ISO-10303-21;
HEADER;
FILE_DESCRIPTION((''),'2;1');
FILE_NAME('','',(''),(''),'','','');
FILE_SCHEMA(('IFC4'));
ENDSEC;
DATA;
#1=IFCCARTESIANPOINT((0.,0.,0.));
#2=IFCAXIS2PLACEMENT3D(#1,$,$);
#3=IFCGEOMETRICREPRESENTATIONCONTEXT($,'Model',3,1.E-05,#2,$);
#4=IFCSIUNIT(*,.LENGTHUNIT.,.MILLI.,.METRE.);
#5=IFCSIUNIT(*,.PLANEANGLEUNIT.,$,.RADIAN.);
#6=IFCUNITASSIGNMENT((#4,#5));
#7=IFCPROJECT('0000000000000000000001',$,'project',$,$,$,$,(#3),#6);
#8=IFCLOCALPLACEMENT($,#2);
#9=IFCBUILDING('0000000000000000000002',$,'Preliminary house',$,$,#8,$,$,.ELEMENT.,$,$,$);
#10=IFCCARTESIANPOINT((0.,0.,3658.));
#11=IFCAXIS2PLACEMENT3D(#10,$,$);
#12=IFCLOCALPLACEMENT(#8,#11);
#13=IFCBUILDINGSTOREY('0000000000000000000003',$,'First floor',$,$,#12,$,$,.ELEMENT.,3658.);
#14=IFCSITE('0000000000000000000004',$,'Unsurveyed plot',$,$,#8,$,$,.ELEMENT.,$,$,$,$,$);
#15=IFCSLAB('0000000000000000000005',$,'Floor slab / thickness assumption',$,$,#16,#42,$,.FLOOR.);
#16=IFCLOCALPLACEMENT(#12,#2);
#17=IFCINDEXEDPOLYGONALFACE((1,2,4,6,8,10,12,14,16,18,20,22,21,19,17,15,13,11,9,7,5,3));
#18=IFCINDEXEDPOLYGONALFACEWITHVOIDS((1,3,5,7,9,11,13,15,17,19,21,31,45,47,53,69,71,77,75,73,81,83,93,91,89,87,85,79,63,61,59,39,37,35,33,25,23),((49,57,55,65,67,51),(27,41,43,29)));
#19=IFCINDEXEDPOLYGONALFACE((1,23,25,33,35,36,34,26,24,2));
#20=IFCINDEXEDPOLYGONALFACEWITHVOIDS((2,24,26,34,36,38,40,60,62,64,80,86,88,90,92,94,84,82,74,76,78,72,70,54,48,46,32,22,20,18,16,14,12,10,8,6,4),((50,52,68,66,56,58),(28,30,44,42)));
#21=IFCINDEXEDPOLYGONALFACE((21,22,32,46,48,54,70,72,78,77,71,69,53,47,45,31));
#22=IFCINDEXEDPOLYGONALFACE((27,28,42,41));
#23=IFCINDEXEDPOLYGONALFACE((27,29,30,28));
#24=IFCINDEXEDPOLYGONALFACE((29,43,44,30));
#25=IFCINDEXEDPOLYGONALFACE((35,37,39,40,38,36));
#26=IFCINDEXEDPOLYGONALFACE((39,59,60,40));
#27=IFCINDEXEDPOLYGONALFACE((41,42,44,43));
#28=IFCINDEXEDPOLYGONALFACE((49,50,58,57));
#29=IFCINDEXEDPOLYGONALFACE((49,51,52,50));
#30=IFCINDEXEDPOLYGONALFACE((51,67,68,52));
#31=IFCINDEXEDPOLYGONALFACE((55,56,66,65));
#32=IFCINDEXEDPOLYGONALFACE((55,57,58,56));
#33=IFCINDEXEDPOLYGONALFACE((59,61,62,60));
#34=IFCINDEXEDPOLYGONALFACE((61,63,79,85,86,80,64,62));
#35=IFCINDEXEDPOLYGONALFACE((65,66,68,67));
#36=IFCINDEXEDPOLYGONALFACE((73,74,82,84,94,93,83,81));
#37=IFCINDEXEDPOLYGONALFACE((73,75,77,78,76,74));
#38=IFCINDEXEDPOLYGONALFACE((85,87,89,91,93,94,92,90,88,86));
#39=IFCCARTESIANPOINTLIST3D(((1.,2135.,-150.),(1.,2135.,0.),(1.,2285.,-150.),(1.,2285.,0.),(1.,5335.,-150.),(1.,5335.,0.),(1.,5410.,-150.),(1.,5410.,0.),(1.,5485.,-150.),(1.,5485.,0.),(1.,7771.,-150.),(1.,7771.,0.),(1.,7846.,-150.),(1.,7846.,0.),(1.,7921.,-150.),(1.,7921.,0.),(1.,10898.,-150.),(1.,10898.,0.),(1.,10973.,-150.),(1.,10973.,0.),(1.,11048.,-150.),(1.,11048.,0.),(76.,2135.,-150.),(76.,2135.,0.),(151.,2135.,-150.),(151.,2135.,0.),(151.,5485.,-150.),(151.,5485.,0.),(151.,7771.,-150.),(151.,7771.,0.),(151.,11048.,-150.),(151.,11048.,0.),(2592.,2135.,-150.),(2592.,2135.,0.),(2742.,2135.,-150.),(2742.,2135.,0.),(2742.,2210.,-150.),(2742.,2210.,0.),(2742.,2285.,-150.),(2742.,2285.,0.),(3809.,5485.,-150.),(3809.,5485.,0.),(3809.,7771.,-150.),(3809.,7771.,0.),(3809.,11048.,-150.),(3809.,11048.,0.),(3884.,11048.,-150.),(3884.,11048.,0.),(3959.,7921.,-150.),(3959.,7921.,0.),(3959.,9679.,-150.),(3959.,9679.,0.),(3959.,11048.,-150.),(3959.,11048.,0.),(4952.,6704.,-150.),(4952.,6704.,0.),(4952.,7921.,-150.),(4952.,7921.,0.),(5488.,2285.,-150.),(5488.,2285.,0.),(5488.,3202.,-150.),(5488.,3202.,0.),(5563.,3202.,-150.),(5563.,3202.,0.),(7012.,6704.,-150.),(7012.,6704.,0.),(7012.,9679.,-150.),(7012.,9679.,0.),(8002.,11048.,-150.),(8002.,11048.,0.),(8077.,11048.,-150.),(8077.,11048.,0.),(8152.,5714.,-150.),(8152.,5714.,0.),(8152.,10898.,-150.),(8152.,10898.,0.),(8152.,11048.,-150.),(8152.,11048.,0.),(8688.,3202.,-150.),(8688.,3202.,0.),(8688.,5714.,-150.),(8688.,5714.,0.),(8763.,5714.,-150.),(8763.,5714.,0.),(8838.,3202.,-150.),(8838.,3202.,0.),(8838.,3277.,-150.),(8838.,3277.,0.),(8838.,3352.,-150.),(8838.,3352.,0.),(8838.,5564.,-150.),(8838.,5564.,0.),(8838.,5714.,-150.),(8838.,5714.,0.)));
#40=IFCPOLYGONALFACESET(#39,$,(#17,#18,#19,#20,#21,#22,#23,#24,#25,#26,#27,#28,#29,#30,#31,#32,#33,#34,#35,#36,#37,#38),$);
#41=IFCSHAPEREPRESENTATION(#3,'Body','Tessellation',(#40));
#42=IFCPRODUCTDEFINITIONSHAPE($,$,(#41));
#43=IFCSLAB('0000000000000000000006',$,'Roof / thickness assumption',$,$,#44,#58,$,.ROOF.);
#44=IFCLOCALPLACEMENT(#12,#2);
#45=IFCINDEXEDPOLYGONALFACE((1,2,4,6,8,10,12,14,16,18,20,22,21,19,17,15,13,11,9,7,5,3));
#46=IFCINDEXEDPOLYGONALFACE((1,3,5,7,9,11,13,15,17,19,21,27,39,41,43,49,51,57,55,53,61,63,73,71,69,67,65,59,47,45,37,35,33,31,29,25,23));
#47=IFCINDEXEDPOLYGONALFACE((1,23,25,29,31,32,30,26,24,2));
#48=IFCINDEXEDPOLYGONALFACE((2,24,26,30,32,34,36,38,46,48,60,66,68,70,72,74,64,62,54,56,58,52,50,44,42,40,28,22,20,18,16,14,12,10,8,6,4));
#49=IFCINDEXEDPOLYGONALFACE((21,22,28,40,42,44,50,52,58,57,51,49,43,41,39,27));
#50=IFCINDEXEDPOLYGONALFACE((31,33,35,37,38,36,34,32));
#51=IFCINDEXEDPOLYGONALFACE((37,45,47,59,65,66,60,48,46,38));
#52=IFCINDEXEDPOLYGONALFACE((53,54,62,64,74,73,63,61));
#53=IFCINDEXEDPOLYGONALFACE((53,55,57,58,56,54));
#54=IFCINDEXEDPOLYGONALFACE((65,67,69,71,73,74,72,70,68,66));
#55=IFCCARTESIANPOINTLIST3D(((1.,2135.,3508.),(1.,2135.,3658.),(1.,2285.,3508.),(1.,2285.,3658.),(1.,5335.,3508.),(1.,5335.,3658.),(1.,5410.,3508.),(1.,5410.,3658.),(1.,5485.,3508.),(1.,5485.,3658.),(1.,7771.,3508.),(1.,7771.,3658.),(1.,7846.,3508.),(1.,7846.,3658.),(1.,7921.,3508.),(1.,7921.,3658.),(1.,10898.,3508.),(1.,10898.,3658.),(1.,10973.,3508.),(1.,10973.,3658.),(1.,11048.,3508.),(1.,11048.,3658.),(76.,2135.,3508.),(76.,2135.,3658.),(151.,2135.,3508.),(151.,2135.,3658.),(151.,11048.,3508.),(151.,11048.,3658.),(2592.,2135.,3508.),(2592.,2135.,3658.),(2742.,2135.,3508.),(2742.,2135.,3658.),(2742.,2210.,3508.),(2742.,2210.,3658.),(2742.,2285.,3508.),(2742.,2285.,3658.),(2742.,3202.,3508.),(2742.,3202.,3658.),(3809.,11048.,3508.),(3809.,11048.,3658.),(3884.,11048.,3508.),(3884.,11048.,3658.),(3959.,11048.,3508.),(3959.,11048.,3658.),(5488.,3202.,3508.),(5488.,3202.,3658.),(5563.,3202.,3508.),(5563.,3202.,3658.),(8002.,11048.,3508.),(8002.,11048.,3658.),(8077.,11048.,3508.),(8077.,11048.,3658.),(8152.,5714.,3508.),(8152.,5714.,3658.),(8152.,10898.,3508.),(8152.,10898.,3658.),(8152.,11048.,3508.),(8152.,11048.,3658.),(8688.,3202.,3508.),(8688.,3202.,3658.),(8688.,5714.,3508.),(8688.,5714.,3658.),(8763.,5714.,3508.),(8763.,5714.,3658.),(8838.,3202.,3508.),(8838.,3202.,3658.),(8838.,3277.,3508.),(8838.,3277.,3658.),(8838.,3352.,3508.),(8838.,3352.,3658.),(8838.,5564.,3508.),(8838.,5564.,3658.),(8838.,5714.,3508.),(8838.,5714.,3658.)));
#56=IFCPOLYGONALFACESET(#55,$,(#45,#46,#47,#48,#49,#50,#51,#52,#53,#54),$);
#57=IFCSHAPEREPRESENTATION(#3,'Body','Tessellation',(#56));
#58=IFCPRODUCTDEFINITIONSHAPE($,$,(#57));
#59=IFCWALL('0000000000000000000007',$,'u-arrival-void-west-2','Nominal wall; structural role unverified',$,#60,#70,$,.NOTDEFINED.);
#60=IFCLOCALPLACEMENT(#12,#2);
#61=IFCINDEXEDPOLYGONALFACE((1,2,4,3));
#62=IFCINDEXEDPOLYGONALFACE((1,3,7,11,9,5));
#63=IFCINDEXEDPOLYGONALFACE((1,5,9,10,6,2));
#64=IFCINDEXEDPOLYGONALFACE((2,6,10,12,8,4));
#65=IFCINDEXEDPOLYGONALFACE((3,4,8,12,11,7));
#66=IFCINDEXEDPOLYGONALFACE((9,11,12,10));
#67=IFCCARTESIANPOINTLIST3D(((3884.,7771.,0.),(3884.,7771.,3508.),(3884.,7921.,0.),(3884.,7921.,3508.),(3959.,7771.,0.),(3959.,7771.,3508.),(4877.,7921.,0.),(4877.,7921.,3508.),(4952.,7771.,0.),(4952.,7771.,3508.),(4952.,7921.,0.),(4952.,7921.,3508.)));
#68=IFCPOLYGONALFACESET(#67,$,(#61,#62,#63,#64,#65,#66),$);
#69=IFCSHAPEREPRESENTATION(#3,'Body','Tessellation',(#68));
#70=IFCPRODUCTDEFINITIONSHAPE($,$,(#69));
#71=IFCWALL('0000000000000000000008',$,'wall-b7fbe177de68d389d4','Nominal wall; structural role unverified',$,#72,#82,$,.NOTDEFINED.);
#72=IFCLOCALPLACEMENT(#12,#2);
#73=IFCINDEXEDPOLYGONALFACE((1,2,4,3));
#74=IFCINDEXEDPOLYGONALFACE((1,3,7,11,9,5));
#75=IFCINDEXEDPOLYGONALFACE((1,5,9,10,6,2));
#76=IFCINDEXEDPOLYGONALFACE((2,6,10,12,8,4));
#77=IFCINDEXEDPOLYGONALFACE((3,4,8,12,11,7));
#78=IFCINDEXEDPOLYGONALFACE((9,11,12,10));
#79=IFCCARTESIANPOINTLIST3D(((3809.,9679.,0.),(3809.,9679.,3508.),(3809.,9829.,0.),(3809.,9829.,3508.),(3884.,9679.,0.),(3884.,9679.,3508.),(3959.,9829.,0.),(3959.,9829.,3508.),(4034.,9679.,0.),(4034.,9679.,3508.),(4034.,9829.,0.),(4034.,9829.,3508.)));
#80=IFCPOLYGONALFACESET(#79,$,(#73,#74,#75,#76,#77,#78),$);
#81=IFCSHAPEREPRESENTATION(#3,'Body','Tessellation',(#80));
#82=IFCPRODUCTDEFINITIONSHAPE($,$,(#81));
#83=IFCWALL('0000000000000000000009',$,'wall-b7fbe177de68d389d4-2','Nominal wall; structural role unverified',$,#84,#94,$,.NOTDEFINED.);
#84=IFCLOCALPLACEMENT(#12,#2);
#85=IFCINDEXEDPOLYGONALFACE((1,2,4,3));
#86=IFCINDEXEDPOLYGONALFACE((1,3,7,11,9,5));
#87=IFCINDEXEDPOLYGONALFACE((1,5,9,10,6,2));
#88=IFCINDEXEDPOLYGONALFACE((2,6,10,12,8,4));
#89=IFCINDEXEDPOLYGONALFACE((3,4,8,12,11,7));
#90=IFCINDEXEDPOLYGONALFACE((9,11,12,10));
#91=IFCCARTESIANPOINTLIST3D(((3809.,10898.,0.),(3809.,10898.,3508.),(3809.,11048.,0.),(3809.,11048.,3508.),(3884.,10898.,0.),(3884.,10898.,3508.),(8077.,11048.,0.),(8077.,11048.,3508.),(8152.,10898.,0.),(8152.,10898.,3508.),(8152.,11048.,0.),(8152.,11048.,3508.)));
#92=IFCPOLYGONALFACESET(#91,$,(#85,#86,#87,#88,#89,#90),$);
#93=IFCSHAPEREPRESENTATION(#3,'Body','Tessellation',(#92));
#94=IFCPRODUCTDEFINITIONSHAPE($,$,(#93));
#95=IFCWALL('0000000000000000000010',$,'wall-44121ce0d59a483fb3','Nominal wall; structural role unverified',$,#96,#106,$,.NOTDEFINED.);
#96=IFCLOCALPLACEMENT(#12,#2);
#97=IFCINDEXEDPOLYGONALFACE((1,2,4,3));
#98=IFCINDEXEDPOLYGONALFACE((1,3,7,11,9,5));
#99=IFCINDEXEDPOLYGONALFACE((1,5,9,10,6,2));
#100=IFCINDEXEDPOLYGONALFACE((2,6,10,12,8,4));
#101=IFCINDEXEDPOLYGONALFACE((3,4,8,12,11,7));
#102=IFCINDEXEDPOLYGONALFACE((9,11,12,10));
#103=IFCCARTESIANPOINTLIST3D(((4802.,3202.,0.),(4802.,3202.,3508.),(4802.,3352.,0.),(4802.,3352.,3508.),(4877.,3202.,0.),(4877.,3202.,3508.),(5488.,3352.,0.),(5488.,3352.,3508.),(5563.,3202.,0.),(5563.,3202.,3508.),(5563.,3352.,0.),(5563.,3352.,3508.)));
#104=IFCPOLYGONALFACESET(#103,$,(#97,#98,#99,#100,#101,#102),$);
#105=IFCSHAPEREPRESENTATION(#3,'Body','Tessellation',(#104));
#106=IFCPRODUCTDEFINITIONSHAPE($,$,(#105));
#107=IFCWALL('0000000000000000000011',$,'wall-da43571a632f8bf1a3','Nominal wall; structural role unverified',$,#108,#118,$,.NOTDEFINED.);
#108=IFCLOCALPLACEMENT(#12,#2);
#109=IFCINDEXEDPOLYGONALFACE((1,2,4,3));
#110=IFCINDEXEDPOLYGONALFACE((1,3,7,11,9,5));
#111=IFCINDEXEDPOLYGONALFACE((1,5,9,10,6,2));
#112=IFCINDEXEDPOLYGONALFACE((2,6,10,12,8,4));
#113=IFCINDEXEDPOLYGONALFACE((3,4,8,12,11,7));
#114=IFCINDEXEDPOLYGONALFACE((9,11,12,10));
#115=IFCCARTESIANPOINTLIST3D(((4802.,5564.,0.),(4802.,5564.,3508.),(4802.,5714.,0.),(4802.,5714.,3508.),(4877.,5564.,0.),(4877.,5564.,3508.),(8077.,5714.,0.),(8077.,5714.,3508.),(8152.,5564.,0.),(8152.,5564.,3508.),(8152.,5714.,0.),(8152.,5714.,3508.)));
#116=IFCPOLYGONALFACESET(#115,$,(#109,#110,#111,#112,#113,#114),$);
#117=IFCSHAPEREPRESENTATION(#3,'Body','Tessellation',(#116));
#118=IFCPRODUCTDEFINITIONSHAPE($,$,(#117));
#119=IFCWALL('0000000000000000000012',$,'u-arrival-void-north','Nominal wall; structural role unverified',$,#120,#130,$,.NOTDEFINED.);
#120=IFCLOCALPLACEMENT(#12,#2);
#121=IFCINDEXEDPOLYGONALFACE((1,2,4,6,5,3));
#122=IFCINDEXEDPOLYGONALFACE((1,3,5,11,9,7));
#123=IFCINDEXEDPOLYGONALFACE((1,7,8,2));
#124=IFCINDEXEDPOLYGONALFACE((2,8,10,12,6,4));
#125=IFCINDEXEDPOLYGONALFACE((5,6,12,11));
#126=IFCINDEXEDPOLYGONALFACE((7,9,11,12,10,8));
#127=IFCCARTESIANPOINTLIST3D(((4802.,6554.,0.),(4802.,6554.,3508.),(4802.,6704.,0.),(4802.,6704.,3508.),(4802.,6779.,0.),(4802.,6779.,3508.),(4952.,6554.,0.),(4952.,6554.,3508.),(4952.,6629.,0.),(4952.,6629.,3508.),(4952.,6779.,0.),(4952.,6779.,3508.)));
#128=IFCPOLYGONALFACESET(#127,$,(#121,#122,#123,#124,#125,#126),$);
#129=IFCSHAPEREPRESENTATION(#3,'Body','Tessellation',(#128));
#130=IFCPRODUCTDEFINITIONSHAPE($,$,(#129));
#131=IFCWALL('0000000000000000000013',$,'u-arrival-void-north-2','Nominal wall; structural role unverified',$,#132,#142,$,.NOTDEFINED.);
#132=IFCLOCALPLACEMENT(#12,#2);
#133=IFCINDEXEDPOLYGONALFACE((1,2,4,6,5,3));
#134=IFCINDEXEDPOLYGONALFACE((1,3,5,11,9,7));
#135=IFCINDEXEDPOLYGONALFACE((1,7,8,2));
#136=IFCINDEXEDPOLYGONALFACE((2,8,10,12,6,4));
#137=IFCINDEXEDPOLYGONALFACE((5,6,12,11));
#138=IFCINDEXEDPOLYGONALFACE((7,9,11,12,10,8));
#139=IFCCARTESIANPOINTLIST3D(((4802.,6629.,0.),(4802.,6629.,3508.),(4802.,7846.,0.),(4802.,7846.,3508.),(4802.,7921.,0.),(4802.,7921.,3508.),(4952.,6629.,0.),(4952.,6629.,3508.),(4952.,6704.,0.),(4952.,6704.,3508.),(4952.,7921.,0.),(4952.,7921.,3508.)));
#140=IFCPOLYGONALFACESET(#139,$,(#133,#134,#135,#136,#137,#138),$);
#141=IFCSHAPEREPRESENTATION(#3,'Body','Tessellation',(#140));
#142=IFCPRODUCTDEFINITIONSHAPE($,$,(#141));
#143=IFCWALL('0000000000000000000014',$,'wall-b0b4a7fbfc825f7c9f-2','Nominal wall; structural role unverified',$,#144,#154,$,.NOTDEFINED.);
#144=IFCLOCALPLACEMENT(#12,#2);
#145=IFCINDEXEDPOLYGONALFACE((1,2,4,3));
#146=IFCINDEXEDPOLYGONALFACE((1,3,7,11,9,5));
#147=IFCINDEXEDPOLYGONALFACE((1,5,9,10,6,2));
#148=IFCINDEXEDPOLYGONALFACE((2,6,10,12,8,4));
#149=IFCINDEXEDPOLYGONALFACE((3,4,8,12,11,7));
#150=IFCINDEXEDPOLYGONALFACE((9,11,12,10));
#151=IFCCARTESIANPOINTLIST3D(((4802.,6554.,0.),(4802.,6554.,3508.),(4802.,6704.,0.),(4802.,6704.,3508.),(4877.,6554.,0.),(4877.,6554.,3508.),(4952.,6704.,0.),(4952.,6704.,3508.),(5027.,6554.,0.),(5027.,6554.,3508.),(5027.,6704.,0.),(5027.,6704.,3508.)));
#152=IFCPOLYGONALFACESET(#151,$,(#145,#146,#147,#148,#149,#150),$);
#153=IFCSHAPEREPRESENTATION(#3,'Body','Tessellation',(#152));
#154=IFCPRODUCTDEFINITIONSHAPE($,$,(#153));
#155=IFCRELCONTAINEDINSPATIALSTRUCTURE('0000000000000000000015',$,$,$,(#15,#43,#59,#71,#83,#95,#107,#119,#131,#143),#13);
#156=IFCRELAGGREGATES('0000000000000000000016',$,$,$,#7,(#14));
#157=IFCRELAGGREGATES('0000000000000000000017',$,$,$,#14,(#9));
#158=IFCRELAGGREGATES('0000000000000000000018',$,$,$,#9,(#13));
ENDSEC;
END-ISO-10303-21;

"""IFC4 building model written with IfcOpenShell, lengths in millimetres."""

from ifc_helpers import new_model, si_unit, frame, origin, place, context, project, spatial, polyline, outline, extrude, element, save


model = new_model("IFC4")

# Units and contexts
model_context = context("Model", 3, precision=1e-05, world=origin())
ifc_project = project(units=[si_unit("LENGTHUNIT", "METRE", prefix="MILLI"), si_unit("PLANEANGLEUNIT", "RADIAN")], contexts=[model_context])

# Site, building, storey
placement_1 = place(None, origin())
site = spatial("IfcSite", under=ifc_project, at=placement_1, Name="Unsurveyed plot", CompositionType="ELEMENT")
building = spatial("IfcBuilding", under=site, at=placement_1, Name="Preliminary house", CompositionType="ELEMENT")
placement_2 = place(placement_1, frame((0.0, 0.0, 3658.0)))
storey = spatial("IfcBuildingStorey", under=building, at=placement_2, Name="First floor", CompositionType="ELEMENT", Elevation=3658.0)

# Slabs
element("IfcSlab", 1, at=placement_2, inside=storey, Name="Floor slab / thickness assumption", PredefinedType="FLOOR", context=model_context, shape_type="SweptSolid", body=[
    extrude(outline(polyline([(1.0, 2285.0), (1.0, 5335.0), (1.0, 5410.0), (1.0, 5485.0), (1.0, 7771.0), (1.0, 7846.0), (1.0, 7921.0), (1.0, 10898.0), (1.0, 10973.0), (1.0, 11048.0), (151.0, 11048.0), (3809.0, 11048.0), (3884.0, 11048.0), (3959.0, 11048.0), (8002.0, 11048.0), (8077.0, 11048.0), (8152.0, 11048.0), (8152.0, 10898.0), (8152.0, 5714.0), (8688.0, 5714.0), (8763.0, 5714.0), (8838.0, 5714.0), (8838.0, 5564.0), (8838.0, 3352.0), (8838.0, 3277.0), (8838.0, 3202.0), (8688.0, 3202.0), (5563.0, 3202.0), (5488.0, 3202.0), (5488.0, 2285.0), (2742.0, 2285.0), (2742.0, 2210.0), (2742.0, 2135.0), (2592.0, 2135.0), (151.0, 2135.0), (76.0, 2135.0), (1.0, 2135.0), (1.0, 2285.0)]), holes=[polyline([(7012.0, 9679.0), (3959.0, 9679.0), (3959.0, 7921.0), (4952.0, 7921.0), (4952.0, 6704.0), (7012.0, 6704.0), (7012.0, 9679.0)]), polyline([(151.0, 7771.0), (151.0, 5485.0), (3809.0, 5485.0), (3809.0, 7771.0), (151.0, 7771.0)])]), frame((0.0, 0.0, -150.0)), (0.0, 0.0, 1.0), 150.0),
])
element("IfcSlab", 2, at=placement_2, inside=storey, Name="Roof / thickness assumption", PredefinedType="ROOF", context=model_context, shape_type="SweptSolid", body=[
    extrude(outline(polyline([(1.0, 2135.0), (1.0, 2285.0), (1.0, 5335.0), (1.0, 5410.0), (1.0, 5485.0), (1.0, 7771.0), (1.0, 7846.0), (1.0, 7921.0), (1.0, 10898.0), (1.0, 10973.0), (1.0, 11048.0), (151.0, 11048.0), (3809.0, 11048.0), (3884.0, 11048.0), (3959.0, 11048.0), (8002.0, 11048.0), (8077.0, 11048.0), (8152.0, 11048.0), (8152.0, 10898.0), (8152.0, 5714.0), (8688.0, 5714.0), (8763.0, 5714.0), (8838.0, 5714.0), (8838.0, 5564.0), (8838.0, 3352.0), (8838.0, 3277.0), (8838.0, 3202.0), (8688.0, 3202.0), (5563.0, 3202.0), (5488.0, 3202.0), (2742.0, 3202.0), (2742.0, 2285.0), (2742.0, 2210.0), (2742.0, 2135.0), (2592.0, 2135.0), (151.0, 2135.0), (76.0, 2135.0), (1.0, 2135.0)])), frame((0.0, 0.0, 3508.0)), (0.0, 0.0, 1.0), 150.0),
])

# Wall
element("IfcWall", 3, at=placement_2, inside=storey, Name="u-arrival-void-west-2", Description="Nominal wall; structural role unverified", PredefinedType="NOTDEFINED", context=model_context, shape_type="SweptSolid", body=[
    extrude(outline(polyline([(4877.0, 7921.0), (4952.0, 7921.0), (4952.0, 7771.0), (3959.0, 7771.0), (3884.0, 7771.0), (3884.0, 7921.0), (4877.0, 7921.0)])), origin(), (0.0, 0.0, 1.0), 3508.0),
])

# Walls
element("IfcWall", 4, at=placement_2, inside=storey, Name="wall-b7fbe177de68d389d4", Description="Nominal wall; structural role unverified", PredefinedType="NOTDEFINED", context=model_context, shape_type="SweptSolid", body=[
    extrude(outline(polyline([(3959.0, 9829.0), (4034.0, 9829.0), (4034.0, 9679.0), (3884.0, 9679.0), (3809.0, 9679.0), (3809.0, 9829.0), (3959.0, 9829.0)])), origin(), (0.0, 0.0, 1.0), 3508.0),
])
element("IfcWall", 5, at=placement_2, inside=storey, Name="wall-b7fbe177de68d389d4-2", Description="Nominal wall; structural role unverified", PredefinedType="NOTDEFINED", context=model_context, shape_type="SweptSolid", body=[
    extrude(outline(polyline([(8077.0, 11048.0), (8152.0, 11048.0), (8152.0, 10898.0), (3884.0, 10898.0), (3809.0, 10898.0), (3809.0, 11048.0), (8077.0, 11048.0)])), origin(), (0.0, 0.0, 1.0), 3508.0),
])

# Wall
element("IfcWall", 6, at=placement_2, inside=storey, Name="wall-44121ce0d59a483fb3", Description="Nominal wall; structural role unverified", PredefinedType="NOTDEFINED", context=model_context, shape_type="SweptSolid", body=[
    extrude(outline(polyline([(5488.0, 3352.0), (5563.0, 3352.0), (5563.0, 3202.0), (4877.0, 3202.0), (4802.0, 3202.0), (4802.0, 3352.0), (5488.0, 3352.0)])), origin(), (0.0, 0.0, 1.0), 3508.0),
])

# Walls
element("IfcWall", 7, at=placement_2, inside=storey, Name="wall-da43571a632f8bf1a3", Description="Nominal wall; structural role unverified", PredefinedType="NOTDEFINED", context=model_context, shape_type="SweptSolid", body=[
    extrude(outline(polyline([(8077.0, 5714.0), (8152.0, 5714.0), (8152.0, 5564.0), (4877.0, 5564.0), (4802.0, 5564.0), (4802.0, 5714.0), (8077.0, 5714.0)])), origin(), (0.0, 0.0, 1.0), 3508.0),
])
element("IfcWall", 8, at=placement_2, inside=storey, Name="u-arrival-void-north", Description="Nominal wall; structural role unverified", PredefinedType="NOTDEFINED", context=model_context, shape_type="SweptSolid", body=[
    extrude(outline(polyline([(4802.0, 6704.0), (4802.0, 6779.0), (4952.0, 6779.0), (4952.0, 6629.0), (4952.0, 6554.0), (4802.0, 6554.0), (4802.0, 6704.0)])), origin(), (0.0, 0.0, 1.0), 3508.0),
])
element("IfcWall", 9, at=placement_2, inside=storey, Name="u-arrival-void-north-2", Description="Nominal wall; structural role unverified", PredefinedType="NOTDEFINED", context=model_context, shape_type="SweptSolid", body=[
    extrude(outline(polyline([(4802.0, 7846.0), (4802.0, 7921.0), (4952.0, 7921.0), (4952.0, 6704.0), (4952.0, 6629.0), (4802.0, 6629.0), (4802.0, 7846.0)])), origin(), (0.0, 0.0, 1.0), 3508.0),
])
element("IfcWall", 10, at=placement_2, inside=storey, Name="wall-b0b4a7fbfc825f7c9f-2", Description="Nominal wall; structural role unverified", PredefinedType="NOTDEFINED", context=model_context, shape_type="SweptSolid", body=[
    extrude(outline(polyline([(4952.0, 6704.0), (5027.0, 6704.0), (5027.0, 6554.0), (4877.0, 6554.0), (4802.0, 6554.0), (4802.0, 6704.0), (4952.0, 6704.0)])), origin(), (0.0, 0.0, 1.0), 3508.0),
])

save(model, "model.ifc")
